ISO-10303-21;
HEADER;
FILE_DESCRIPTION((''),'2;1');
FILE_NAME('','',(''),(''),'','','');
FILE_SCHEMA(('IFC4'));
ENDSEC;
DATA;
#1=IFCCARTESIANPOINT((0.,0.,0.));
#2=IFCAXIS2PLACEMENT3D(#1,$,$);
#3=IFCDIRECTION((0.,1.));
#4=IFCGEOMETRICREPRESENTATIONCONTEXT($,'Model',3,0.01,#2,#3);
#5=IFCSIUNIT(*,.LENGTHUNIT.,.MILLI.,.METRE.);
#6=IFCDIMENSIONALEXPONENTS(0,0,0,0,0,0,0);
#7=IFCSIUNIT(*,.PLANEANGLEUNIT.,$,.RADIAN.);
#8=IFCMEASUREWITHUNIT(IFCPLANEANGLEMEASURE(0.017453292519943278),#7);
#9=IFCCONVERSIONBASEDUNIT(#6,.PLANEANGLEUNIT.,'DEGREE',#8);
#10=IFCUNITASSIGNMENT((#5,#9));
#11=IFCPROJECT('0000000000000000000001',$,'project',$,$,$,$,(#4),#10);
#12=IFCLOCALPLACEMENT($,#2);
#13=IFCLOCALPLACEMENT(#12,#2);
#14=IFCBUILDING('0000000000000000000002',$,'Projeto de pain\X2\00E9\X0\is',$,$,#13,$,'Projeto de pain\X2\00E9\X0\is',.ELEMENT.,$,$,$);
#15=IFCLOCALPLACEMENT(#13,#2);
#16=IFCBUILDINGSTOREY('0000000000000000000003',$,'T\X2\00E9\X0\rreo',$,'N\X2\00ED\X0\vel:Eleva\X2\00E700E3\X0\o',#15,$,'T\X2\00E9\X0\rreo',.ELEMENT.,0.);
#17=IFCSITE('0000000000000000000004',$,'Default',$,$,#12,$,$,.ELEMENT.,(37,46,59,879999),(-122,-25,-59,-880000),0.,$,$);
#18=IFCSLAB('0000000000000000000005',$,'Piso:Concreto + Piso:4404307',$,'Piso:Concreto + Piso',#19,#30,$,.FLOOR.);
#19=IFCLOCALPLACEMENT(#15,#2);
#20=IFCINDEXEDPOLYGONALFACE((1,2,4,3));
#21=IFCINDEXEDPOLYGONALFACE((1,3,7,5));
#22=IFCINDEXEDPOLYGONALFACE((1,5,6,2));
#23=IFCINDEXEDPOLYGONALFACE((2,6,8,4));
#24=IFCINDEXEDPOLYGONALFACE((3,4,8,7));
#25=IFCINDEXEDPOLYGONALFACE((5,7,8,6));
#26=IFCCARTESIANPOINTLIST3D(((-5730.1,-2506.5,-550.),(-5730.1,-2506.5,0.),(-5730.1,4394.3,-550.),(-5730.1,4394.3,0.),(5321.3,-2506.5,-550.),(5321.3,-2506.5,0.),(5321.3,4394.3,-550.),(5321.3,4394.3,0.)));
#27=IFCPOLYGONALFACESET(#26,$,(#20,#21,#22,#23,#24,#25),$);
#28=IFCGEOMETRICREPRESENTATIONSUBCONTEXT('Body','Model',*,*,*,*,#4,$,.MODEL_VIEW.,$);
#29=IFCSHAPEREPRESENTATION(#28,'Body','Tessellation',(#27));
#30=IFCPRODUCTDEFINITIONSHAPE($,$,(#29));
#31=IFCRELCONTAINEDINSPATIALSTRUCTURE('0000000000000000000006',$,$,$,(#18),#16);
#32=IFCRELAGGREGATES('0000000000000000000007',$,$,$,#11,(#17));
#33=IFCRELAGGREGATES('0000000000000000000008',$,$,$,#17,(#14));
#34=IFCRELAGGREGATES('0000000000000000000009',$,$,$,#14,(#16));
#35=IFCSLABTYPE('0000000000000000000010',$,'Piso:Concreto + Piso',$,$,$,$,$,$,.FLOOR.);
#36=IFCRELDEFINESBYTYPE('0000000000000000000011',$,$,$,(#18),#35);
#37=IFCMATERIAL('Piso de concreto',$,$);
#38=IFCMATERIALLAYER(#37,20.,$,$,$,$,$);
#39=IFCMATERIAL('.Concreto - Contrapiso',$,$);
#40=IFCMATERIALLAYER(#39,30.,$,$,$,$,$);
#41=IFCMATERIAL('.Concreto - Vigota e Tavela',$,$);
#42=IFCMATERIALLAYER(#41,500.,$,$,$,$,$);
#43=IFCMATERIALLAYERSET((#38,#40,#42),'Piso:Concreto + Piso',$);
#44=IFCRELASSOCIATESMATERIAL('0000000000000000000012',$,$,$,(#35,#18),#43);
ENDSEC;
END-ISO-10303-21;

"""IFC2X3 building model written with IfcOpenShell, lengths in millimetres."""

from ifc_helpers import new_model, entity, si_unit, converted_unit, direction, frame, frame_2d, origin, place, context, subcontext, project, spatial, rectangle, extrude, material, layer, layer_set, layer_usage, type_object, element, save


model = new_model("IFC2X3")

# Units and contexts
model_context = context("Model", 3, precision=0.01, world=origin(), true_north=direction((0.0, 1.0)))
body_context = subcontext(model_context, "Body", "Model", "MODEL_VIEW")
ifc_project = project(units=[si_unit("LENGTHUNIT", "METRE", prefix="MILLI"), converted_unit("PLANEANGLEUNIT", "DEGREE", entity("IfcPlaneAngleMeasure", 0.017453292519943278), si_unit("PLANEANGLEUNIT", "RADIAN"), dimensions=[0, 0, 0, 0, 0, 0, 0])], contexts=[model_context])

# Site, building, storey
site_placement = place(None, origin())
site = spatial("IfcSite", under=ifc_project, at=site_placement, Name="Default", CompositionType="ELEMENT", RefLatitude=(37, 46, 59, 879999), RefLongitude=(-122, -25, -59, -880000), RefElevation=0.0)
building_placement = place(site_placement, origin())
building = spatial("IfcBuilding", under=site, at=building_placement, Name="Projeto de painéis", LongName="Projeto de painéis", CompositionType="ELEMENT")
storey_placement = place(building_placement, origin())
storey = spatial("IfcBuildingStorey", under=building, at=storey_placement, Name="Térreo", ObjectType="Nível:Elevação", LongName="Térreo", CompositionType="ELEMENT", Elevation=0.0)

# Slab
ifc_material_1 = material(Name="Piso de concreto")
ifc_layer_1 = layer(ifc_material_1, 20.0)
ifc_material_2 = material(Name=".Concreto - Contrapiso")
ifc_layer_2 = layer(ifc_material_2, 30.0)
ifc_material_3 = material(Name=".Concreto - Vigota e Tavela")
ifc_layer_3 = layer(ifc_material_3, 500.0)
ifc_layer_set = layer_set([ifc_layer_1, ifc_layer_2, ifc_layer_3], Name="Piso:Concreto + Piso")
ifc_layer_usage = layer_usage(ifc_layer_set, "AXIS3", "POSITIVE", 0.0)
slab_type = type_object("IfcSlabType", Name="Piso:Concreto + Piso", PredefinedType="FLOOR", material=ifc_layer_set)
slab_placement = place(storey_placement, origin())
element("IfcSlab", 1, at=slab_placement, inside=storey, type_object=slab_type, material=ifc_layer_usage, Name="Piso:Concreto + Piso:4404307", ObjectType="Piso:Concreto + Piso", PredefinedType="FLOOR", context=body_context, shape_type="SweptSolid", body=[
    extrude(rectangle(XDim=6900.9, YDim=11051.4, at=frame_2d((0.0, 0.0), x_axis=(1.0, 0.0))), frame((-204.4, 943.9, 0.0), z_axis=(0.0, 0.0, -1.0), x_axis=(0.0, 1.0, 0.0)), (0.0, 0.0, 1.0), 550.0),
])

save(model, "model.ifc")
